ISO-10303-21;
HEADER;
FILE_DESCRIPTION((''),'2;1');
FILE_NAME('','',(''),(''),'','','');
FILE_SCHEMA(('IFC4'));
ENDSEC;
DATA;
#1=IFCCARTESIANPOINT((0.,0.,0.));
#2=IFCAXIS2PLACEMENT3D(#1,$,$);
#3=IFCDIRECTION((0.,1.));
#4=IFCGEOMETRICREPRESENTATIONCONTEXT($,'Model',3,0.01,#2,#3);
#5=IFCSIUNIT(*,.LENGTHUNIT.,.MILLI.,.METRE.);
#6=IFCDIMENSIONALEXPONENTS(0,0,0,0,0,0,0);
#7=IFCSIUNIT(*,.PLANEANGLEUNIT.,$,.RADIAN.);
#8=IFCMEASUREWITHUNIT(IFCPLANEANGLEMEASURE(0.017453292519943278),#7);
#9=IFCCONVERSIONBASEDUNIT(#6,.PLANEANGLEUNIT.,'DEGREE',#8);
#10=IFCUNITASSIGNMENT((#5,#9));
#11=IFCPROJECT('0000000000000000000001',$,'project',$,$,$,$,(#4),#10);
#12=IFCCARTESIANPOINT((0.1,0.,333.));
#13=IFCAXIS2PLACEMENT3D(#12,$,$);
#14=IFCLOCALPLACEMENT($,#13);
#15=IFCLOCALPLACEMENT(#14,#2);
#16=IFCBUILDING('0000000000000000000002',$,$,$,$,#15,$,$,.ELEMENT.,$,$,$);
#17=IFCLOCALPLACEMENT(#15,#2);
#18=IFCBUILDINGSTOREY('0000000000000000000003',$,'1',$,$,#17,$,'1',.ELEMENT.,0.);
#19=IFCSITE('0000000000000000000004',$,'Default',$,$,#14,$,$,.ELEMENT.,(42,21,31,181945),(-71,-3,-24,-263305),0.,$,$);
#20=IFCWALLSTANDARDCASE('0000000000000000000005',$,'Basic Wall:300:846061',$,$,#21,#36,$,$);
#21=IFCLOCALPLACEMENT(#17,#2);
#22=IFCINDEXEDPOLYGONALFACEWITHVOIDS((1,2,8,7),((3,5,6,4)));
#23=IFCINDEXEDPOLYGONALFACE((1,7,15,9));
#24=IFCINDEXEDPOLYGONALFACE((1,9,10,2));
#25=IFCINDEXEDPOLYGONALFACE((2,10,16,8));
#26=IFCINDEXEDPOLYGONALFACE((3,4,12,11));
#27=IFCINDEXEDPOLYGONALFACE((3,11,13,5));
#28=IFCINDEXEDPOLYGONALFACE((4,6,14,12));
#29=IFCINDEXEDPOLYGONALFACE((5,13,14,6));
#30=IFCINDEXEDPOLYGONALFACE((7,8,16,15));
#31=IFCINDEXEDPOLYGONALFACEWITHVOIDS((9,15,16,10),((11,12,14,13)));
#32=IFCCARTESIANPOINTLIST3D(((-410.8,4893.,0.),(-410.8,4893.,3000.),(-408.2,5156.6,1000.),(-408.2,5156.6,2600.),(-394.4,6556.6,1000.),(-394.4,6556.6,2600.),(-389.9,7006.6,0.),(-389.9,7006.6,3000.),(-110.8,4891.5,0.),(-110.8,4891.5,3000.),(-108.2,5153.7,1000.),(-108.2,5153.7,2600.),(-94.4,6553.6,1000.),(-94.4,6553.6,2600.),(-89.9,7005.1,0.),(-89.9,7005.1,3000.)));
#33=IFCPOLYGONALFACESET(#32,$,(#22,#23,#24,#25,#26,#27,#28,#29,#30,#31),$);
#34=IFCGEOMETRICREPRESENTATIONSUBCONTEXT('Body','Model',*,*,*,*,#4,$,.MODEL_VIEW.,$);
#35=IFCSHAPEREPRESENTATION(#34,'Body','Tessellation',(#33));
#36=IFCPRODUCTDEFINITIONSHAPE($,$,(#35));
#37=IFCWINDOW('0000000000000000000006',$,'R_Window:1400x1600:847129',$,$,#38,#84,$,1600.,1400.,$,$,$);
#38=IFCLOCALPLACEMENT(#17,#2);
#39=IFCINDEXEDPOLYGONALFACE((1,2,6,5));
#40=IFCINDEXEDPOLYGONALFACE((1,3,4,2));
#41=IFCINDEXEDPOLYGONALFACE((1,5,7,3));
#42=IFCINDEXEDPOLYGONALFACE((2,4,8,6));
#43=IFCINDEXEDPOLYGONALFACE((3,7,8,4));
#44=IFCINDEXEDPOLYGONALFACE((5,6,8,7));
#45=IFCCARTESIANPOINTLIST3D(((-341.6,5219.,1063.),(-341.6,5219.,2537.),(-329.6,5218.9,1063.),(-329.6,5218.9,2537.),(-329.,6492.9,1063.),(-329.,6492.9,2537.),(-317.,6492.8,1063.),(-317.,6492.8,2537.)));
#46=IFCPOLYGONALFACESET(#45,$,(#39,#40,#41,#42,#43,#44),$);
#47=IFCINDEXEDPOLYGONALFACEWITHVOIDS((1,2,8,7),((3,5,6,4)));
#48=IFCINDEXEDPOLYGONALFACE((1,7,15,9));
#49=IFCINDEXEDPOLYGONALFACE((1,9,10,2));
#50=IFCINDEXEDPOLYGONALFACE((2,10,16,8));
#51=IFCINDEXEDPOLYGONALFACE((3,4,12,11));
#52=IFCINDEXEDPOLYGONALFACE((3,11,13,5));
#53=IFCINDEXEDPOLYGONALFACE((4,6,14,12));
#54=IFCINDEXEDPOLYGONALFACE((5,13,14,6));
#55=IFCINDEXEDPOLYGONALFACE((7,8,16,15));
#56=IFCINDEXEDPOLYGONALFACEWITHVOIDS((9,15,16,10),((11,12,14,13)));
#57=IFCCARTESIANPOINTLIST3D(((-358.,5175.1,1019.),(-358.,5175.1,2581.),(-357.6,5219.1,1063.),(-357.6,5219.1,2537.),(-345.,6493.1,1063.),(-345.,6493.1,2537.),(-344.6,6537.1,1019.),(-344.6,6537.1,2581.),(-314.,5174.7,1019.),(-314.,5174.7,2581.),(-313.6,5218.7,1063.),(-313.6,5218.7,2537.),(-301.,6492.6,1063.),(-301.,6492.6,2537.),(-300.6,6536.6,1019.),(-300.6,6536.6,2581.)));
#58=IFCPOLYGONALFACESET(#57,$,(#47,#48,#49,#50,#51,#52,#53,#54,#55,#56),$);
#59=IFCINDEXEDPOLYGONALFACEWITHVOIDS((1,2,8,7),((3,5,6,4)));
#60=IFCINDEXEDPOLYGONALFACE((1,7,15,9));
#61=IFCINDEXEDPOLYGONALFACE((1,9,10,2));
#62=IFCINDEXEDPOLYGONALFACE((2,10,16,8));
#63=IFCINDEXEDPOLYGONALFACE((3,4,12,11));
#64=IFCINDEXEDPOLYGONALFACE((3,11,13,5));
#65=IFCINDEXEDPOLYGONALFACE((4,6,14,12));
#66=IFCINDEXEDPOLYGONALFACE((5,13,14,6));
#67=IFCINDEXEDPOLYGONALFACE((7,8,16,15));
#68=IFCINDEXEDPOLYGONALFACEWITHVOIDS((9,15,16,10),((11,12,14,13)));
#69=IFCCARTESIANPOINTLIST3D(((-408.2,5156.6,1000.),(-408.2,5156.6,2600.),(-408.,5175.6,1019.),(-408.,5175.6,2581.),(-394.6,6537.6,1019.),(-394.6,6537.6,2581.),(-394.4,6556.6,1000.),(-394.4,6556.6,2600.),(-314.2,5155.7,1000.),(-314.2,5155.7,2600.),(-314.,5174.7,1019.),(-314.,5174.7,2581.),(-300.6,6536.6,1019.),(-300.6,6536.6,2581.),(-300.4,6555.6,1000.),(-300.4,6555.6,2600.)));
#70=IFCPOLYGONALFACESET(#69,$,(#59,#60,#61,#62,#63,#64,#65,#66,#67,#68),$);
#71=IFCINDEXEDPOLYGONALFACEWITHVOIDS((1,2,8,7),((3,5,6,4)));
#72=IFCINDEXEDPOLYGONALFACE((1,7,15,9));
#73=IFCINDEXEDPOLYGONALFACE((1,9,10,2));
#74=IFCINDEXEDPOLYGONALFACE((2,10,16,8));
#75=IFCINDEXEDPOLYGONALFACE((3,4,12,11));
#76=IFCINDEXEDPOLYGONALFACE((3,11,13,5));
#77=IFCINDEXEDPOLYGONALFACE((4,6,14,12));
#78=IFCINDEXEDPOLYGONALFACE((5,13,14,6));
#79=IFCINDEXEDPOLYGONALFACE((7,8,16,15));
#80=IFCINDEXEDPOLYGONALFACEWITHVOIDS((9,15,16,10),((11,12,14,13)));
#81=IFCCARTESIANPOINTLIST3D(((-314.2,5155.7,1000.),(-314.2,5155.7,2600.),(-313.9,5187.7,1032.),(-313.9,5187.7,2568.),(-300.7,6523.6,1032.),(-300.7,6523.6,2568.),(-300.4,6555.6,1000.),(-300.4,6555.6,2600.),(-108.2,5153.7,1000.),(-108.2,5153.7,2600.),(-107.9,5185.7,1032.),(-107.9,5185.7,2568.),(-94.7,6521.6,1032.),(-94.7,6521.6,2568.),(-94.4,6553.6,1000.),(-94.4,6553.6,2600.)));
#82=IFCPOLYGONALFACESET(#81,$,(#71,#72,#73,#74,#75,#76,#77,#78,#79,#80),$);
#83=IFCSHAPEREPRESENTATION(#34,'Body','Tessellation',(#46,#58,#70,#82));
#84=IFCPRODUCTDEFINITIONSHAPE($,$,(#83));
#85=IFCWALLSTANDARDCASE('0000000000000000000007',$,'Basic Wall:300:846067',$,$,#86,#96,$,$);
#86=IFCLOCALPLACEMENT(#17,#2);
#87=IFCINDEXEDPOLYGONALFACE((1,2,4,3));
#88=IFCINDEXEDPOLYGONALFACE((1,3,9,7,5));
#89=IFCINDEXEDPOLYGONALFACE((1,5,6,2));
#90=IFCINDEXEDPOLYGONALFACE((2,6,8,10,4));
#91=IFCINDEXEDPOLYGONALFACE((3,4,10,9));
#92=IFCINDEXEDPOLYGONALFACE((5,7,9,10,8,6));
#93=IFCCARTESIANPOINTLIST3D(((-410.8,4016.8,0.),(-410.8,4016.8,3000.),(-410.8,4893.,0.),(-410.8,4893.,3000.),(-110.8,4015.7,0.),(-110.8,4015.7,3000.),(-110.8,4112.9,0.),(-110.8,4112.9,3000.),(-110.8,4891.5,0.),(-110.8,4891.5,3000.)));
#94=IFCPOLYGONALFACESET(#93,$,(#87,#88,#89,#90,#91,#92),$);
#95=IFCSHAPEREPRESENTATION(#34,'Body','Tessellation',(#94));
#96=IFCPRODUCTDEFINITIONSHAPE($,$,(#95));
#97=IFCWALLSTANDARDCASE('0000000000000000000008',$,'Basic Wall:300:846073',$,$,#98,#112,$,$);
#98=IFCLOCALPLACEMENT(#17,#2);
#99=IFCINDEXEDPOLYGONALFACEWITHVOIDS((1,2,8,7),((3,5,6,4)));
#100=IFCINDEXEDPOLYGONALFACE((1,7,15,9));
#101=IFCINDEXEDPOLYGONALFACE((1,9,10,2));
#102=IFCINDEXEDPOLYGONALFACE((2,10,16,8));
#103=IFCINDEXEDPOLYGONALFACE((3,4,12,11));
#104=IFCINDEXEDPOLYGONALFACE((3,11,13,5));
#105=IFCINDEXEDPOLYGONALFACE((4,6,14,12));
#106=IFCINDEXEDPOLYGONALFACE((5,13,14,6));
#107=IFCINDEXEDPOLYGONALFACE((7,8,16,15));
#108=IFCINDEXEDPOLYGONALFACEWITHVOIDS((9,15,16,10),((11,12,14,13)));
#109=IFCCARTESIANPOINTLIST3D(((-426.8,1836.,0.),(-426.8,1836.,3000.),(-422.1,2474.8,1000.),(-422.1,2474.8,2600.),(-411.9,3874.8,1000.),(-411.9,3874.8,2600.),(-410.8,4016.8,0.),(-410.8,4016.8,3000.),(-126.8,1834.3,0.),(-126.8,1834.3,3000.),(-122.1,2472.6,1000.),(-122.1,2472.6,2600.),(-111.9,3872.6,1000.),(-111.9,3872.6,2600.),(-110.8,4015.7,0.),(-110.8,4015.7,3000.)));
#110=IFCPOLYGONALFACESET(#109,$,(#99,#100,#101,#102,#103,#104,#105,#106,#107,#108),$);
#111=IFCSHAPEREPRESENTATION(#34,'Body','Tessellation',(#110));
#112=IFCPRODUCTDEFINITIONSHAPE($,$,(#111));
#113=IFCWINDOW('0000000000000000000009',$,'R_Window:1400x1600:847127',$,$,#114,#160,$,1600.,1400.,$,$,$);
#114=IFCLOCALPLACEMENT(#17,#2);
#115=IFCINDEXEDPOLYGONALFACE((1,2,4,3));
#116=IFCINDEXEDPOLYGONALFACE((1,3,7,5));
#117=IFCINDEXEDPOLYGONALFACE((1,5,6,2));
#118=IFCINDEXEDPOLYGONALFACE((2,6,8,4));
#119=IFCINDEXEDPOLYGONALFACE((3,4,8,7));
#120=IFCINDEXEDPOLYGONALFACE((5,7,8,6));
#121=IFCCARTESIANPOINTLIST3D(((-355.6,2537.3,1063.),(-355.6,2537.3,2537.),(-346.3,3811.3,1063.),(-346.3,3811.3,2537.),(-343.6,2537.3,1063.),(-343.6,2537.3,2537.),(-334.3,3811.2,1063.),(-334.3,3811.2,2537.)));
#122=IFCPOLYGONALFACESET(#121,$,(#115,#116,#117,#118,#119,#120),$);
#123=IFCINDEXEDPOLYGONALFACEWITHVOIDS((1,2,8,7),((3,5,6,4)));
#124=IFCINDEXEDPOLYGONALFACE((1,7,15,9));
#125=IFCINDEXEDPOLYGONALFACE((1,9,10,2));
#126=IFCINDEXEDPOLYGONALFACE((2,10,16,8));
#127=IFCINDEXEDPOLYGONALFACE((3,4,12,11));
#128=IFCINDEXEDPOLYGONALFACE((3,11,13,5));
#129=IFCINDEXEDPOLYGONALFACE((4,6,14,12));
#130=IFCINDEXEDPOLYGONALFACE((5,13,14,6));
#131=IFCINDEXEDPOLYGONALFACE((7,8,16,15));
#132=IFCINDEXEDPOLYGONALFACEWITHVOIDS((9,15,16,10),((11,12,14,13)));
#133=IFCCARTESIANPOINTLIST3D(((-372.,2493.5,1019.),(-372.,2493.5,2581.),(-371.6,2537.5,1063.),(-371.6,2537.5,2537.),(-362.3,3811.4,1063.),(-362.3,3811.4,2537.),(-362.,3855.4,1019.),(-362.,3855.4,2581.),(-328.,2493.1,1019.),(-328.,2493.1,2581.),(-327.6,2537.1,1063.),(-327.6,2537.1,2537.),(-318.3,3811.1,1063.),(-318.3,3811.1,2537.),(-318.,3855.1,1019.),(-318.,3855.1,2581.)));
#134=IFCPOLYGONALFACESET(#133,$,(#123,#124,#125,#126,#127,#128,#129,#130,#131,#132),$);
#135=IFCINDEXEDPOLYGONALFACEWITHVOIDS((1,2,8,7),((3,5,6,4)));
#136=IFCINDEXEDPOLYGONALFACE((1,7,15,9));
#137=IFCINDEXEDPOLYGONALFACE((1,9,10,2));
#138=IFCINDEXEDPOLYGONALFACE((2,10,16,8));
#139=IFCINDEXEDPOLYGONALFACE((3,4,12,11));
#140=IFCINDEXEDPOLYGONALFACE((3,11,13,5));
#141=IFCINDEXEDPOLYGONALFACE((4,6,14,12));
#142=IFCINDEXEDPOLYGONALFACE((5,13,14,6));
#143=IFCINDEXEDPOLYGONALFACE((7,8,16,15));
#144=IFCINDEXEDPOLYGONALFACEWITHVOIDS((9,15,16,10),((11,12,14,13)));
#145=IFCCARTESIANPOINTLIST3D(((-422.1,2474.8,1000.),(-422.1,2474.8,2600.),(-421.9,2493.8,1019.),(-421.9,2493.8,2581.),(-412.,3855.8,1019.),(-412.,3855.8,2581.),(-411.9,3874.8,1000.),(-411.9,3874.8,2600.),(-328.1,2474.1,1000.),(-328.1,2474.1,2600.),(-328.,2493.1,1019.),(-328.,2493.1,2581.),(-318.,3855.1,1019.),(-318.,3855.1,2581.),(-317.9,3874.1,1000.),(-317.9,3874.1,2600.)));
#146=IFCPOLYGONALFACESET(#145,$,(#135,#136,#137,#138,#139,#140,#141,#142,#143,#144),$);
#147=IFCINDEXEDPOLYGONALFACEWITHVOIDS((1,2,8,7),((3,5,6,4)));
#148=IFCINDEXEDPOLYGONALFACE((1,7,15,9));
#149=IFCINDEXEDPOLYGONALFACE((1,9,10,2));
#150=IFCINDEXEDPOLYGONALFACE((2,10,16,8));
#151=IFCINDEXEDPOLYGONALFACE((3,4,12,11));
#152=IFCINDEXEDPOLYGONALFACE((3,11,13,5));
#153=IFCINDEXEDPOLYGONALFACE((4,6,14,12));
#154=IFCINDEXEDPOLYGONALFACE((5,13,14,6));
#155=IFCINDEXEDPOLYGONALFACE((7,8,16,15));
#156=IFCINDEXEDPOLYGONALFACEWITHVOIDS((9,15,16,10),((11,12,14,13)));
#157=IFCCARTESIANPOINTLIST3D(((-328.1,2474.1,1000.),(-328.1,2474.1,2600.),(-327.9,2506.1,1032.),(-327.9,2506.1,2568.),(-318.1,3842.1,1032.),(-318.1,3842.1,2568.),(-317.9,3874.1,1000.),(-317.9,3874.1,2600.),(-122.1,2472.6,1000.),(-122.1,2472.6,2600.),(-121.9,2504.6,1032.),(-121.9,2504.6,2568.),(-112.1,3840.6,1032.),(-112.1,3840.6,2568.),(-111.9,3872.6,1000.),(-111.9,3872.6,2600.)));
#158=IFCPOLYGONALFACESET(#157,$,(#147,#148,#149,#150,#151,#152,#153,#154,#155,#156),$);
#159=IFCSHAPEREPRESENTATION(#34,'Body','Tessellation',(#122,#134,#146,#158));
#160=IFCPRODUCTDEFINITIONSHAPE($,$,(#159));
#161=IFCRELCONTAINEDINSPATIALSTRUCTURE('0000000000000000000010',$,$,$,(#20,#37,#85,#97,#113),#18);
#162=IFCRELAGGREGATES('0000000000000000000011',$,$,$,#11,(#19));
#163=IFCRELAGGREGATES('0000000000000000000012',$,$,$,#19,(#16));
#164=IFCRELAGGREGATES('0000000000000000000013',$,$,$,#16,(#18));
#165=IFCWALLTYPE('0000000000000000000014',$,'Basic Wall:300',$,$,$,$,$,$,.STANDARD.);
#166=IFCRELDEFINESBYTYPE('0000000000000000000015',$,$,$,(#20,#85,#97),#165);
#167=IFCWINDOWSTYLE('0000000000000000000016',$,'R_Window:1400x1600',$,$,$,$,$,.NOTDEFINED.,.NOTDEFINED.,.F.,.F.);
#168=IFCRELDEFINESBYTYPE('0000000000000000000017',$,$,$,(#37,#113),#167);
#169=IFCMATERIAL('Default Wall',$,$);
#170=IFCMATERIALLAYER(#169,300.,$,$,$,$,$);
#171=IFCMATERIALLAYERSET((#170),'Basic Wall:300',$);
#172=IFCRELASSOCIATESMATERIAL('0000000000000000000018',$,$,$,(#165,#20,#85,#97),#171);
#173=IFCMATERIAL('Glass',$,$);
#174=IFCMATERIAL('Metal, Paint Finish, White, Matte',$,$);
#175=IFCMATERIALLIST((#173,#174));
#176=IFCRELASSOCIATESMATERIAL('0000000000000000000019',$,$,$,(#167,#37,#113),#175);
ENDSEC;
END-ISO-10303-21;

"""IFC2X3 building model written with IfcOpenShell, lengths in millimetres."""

from ifc_helpers import new_model, entity, si_unit, converted_unit, direction, frame, frame_2d, origin, place, context, subcontext, project, spatial, polyline, rectangle, outline, extrude, source, transform, mapped, material, material_list, layer, layer_set, layer_usage, type_object, type_shapes, element, fill, save


model = new_model("IFC2X3")

# Units and contexts
model_context = context("Model", 3, precision=0.01, world=origin(), true_north=direction((0.0, 1.0)))
body_context = subcontext(model_context, "Body", "Model", "MODEL_VIEW")
ifc_project = project(units=[si_unit("LENGTHUNIT", "METRE", prefix="MILLI"), converted_unit("PLANEANGLEUNIT", "DEGREE", entity("IfcPlaneAngleMeasure", 0.017453292519943278), si_unit("PLANEANGLEUNIT", "RADIAN"), dimensions=[0, 0, 0, 0, 0, 0, 0])], contexts=[model_context])

# Site, building, storey
site_placement = place(None, frame((0.1, 0.0, 333.0)))
site = spatial("IfcSite", under=ifc_project, at=site_placement, Name="Default", CompositionType="ELEMENT", RefLatitude=(42, 21, 31, 181945), RefLongitude=(-71, -3, -24, -263305), RefElevation=0.0)
building_placement = place(site_placement, origin())
building = spatial("IfcBuilding", under=site, at=building_placement, CompositionType="ELEMENT")
storey_placement = place(building_placement, origin())
storey = spatial("IfcBuildingStorey", under=building, at=storey_placement, Name="1", LongName="1", CompositionType="ELEMENT", Elevation=0.0)

# Wall, opening, window
ifc_material_1 = material(Name="Default Wall")
ifc_layer_1 = layer(ifc_material_1, 300.0)
ifc_layer_set_1 = layer_set([ifc_layer_1], Name="Basic Wall:300")
ifc_layer_usage_1 = layer_usage(ifc_layer_set_1, "AXIS2", "NEGATIVE", 150.0)
wall_type_1 = type_object("IfcWallType", Name="Basic Wall:300", PredefinedType="STANDARD", material=ifc_layer_set_1)
wall_1_placement = place(storey_placement, frame((-260.8, 4891.5, 0.0), z_axis=(0.0, 0.0, 1.0), x_axis=(0.009898, 0.999951, 0.0)))
wall_1 = element("IfcWallStandardCase", 1, at=wall_1_placement, inside=storey, type_object=wall_type_1, material=ifc_layer_usage_1, Name="Basic Wall:300:846061", context=body_context, shape_type="SweptSolid", body=[
    extrude(outline(polyline([(2115.2, -150.0), (2113.7, 150.0), (0.0, 150.0), (1.5, -150.0), (2115.2, -150.0)])), origin(), (0.0, 0.0, 1.0), 3000.0),
])
opening_1_placement = place(wall_1_placement, frame((263.7, -150.0, 1000.0)))
opening_1 = element("IfcOpeningElement", 2, at=opening_1_placement, cuts=wall_1, ObjectType="Opening", context=body_context, shape_type="SweptSolid", body=[
    extrude(rectangle(XDim=1600.0, YDim=1400.0, at=frame_2d((800.0, 700.0), x_axis=(1.0, 0.0))), frame((0.0, 0.0, 0.0), z_axis=(0.0, 1.0, 0.0), x_axis=(0.0, 0.0, 1.0)), (0.0, 0.0, 1.0), 300.0),
])
ifc_material_2 = material(Name="Glass")
ifc_material_3 = material(Name="Metal, Paint Finish, White, Matte")
ifc_material_list_1 = material_list([ifc_material_2, ifc_material_3])
window_style = type_object("IfcWindowStyle", Name="R_Window:1400x1600", ConstructionType="NOTDEFINED", OperationType="NOTDEFINED", ParameterTakesPrecedence=False, Sizeable=False, material=ifc_material_list_1)
shared_shape_1 = source(origin(), body_context, "Body", "SweptSolid", [
    extrude(rectangle(XDim=12.0, YDim=1274.0, at=frame_2d((0.0, 0.0), x_axis=(1.0, 0.0))), frame((700.0, 228.0, 63.0), z_axis=(0.0, 0.0, 1.0), x_axis=(0.0, -1.0, 0.0)), (0.0, 0.0, 1.0), 1474.0),
    extrude(outline(polyline([(-681.0, -781.0), (681.0, -781.0), (681.0, 781.0), (-681.0, 781.0), (-681.0, -781.0)]), holes=[polyline([(-637.0, -737.0), (-637.0, 737.0), (637.0, 737.0), (637.0, -737.0), (-637.0, -737.0)])]), frame((700.0, 206.0, 800.0), z_axis=(0.0, 1.0, 0.0), x_axis=(1.0, 0.0, 0.0)), (0.0, 0.0, 1.0), 44.0),
    extrude(outline(polyline([(-700.0, -800.0), (700.0, -800.0), (700.0, 800.0), (-700.0, 800.0), (-700.0, -800.0)]), holes=[polyline([(-681.0, -781.0), (-681.0, 781.0), (681.0, 781.0), (681.0, -781.0), (-681.0, -781.0)])]), frame((700.0, 206.0, 800.0), z_axis=(0.0, 1.0, 0.0), x_axis=(1.0, 0.0, 0.0)), (0.0, 0.0, 1.0), 94.0),
    extrude(outline(polyline([(-700.0, -800.0), (700.0, -800.0), (700.0, 800.0), (-700.0, 800.0), (-700.0, -800.0)]), holes=[polyline([(-668.0, -768.0), (-668.0, 768.0), (668.0, 768.0), (668.0, -768.0), (-668.0, -768.0)])]), frame((700.0, 0.0, 800.0), z_axis=(0.0, 1.0, 0.0), x_axis=(1.0, 0.0, 0.0)), (0.0, 0.0, 1.0), 206.0),
])
type_shapes(window_style, [shared_shape_1])
window_1_placement = place(opening_1_placement, origin())
window_1 = element("IfcWindow", 3, at=window_1_placement, inside=storey, type_object=window_style, material=ifc_material_list_1, Name="R_Window:1400x1600:847129", OverallHeight=1600.0, OverallWidth=1400.0, context=body_context, shape_type="MappedRepresentation", body=[
    mapped(shared_shape_1, transform((0.0, 0.0, 0.0), scale=1.0)),
])
fill(opening_1, window_1)

# Wall
ifc_layer_usage_2 = layer_usage(ifc_layer_set_1, "AXIS2", "NEGATIVE", 150.0)
wall_2_placement = place(storey_placement, frame((-260.8, 4015.7, 0.0), z_axis=(0.0, 0.0, 1.0), x_axis=(0.0, 1.0, 0.0)))
element("IfcWallStandardCase", 4, at=wall_2_placement, inside=storey, type_object=wall_type_1, material=ifc_layer_usage_2, Name="Basic Wall:300:846067", context=body_context, shape_type="SweptSolid", body=[
    extrude(outline(polyline([(875.8, -150.0), (877.3, 150.0), (1.1, 150.0), (0.0, -150.0), (97.1, -150.0), (875.8, -150.0)])), origin(), (0.0, 0.0, 1.0), 3000.0),
])

# Wall, opening, window
ifc_layer_usage_3 = layer_usage(ifc_layer_set_1, "AXIS2", "NEGATIVE", 150.0)
wall_3_placement = place(storey_placement, frame((-276.8, 1834.9, 0.0), z_axis=(0.0, 0.0, 1.0), x_axis=(0.007299, 0.999973, 0.0)))
wall_3 = element("IfcWallStandardCase", 5, at=wall_3_placement, inside=storey, type_object=wall_type_1, material=ifc_layer_usage_3, Name="Basic Wall:300:846073", context=body_context, shape_type="SweptSolid", body=[
    extrude(outline(polyline([(2182.0, -150.0), (2180.9, 150.0), (0.0, 150.0), (0.5, -150.0), (445.8, -150.0), (545.9, -150.0), (2179.1, -150.0), (2182.0, -150.0)])), origin(), (0.0, 0.0, 1.0), 3000.0),
])
opening_2_placement = place(wall_3_placement, frame((638.9, -150.0, 1000.0)))
opening_2 = element("IfcOpeningElement", 6, at=opening_2_placement, cuts=wall_3, ObjectType="Opening", context=body_context, shape_type="SweptSolid", body=[
    extrude(rectangle(XDim=1600.0, YDim=1400.0, at=frame_2d((800.0, 700.0), x_axis=(1.0, 0.0))), frame((0.0, 0.0, 0.0), z_axis=(0.0, 1.0, 0.0), x_axis=(0.0, 0.0, 1.0)), (0.0, 0.0, 1.0), 300.0),
])
window_2_placement = place(opening_2_placement, origin())
window_2 = element("IfcWindow", 7, at=window_2_placement, inside=storey, type_object=window_style, material=ifc_material_list_1, Name="R_Window:1400x1600:847127", OverallHeight=1600.0, OverallWidth=1400.0, context=body_context, shape_type="MappedRepresentation", body=[
    mapped(shared_shape_1, transform((0.0, 0.0, 0.0), scale=1.0)),
])
fill(opening_2, window_2)

save(model, "model.ifc")
